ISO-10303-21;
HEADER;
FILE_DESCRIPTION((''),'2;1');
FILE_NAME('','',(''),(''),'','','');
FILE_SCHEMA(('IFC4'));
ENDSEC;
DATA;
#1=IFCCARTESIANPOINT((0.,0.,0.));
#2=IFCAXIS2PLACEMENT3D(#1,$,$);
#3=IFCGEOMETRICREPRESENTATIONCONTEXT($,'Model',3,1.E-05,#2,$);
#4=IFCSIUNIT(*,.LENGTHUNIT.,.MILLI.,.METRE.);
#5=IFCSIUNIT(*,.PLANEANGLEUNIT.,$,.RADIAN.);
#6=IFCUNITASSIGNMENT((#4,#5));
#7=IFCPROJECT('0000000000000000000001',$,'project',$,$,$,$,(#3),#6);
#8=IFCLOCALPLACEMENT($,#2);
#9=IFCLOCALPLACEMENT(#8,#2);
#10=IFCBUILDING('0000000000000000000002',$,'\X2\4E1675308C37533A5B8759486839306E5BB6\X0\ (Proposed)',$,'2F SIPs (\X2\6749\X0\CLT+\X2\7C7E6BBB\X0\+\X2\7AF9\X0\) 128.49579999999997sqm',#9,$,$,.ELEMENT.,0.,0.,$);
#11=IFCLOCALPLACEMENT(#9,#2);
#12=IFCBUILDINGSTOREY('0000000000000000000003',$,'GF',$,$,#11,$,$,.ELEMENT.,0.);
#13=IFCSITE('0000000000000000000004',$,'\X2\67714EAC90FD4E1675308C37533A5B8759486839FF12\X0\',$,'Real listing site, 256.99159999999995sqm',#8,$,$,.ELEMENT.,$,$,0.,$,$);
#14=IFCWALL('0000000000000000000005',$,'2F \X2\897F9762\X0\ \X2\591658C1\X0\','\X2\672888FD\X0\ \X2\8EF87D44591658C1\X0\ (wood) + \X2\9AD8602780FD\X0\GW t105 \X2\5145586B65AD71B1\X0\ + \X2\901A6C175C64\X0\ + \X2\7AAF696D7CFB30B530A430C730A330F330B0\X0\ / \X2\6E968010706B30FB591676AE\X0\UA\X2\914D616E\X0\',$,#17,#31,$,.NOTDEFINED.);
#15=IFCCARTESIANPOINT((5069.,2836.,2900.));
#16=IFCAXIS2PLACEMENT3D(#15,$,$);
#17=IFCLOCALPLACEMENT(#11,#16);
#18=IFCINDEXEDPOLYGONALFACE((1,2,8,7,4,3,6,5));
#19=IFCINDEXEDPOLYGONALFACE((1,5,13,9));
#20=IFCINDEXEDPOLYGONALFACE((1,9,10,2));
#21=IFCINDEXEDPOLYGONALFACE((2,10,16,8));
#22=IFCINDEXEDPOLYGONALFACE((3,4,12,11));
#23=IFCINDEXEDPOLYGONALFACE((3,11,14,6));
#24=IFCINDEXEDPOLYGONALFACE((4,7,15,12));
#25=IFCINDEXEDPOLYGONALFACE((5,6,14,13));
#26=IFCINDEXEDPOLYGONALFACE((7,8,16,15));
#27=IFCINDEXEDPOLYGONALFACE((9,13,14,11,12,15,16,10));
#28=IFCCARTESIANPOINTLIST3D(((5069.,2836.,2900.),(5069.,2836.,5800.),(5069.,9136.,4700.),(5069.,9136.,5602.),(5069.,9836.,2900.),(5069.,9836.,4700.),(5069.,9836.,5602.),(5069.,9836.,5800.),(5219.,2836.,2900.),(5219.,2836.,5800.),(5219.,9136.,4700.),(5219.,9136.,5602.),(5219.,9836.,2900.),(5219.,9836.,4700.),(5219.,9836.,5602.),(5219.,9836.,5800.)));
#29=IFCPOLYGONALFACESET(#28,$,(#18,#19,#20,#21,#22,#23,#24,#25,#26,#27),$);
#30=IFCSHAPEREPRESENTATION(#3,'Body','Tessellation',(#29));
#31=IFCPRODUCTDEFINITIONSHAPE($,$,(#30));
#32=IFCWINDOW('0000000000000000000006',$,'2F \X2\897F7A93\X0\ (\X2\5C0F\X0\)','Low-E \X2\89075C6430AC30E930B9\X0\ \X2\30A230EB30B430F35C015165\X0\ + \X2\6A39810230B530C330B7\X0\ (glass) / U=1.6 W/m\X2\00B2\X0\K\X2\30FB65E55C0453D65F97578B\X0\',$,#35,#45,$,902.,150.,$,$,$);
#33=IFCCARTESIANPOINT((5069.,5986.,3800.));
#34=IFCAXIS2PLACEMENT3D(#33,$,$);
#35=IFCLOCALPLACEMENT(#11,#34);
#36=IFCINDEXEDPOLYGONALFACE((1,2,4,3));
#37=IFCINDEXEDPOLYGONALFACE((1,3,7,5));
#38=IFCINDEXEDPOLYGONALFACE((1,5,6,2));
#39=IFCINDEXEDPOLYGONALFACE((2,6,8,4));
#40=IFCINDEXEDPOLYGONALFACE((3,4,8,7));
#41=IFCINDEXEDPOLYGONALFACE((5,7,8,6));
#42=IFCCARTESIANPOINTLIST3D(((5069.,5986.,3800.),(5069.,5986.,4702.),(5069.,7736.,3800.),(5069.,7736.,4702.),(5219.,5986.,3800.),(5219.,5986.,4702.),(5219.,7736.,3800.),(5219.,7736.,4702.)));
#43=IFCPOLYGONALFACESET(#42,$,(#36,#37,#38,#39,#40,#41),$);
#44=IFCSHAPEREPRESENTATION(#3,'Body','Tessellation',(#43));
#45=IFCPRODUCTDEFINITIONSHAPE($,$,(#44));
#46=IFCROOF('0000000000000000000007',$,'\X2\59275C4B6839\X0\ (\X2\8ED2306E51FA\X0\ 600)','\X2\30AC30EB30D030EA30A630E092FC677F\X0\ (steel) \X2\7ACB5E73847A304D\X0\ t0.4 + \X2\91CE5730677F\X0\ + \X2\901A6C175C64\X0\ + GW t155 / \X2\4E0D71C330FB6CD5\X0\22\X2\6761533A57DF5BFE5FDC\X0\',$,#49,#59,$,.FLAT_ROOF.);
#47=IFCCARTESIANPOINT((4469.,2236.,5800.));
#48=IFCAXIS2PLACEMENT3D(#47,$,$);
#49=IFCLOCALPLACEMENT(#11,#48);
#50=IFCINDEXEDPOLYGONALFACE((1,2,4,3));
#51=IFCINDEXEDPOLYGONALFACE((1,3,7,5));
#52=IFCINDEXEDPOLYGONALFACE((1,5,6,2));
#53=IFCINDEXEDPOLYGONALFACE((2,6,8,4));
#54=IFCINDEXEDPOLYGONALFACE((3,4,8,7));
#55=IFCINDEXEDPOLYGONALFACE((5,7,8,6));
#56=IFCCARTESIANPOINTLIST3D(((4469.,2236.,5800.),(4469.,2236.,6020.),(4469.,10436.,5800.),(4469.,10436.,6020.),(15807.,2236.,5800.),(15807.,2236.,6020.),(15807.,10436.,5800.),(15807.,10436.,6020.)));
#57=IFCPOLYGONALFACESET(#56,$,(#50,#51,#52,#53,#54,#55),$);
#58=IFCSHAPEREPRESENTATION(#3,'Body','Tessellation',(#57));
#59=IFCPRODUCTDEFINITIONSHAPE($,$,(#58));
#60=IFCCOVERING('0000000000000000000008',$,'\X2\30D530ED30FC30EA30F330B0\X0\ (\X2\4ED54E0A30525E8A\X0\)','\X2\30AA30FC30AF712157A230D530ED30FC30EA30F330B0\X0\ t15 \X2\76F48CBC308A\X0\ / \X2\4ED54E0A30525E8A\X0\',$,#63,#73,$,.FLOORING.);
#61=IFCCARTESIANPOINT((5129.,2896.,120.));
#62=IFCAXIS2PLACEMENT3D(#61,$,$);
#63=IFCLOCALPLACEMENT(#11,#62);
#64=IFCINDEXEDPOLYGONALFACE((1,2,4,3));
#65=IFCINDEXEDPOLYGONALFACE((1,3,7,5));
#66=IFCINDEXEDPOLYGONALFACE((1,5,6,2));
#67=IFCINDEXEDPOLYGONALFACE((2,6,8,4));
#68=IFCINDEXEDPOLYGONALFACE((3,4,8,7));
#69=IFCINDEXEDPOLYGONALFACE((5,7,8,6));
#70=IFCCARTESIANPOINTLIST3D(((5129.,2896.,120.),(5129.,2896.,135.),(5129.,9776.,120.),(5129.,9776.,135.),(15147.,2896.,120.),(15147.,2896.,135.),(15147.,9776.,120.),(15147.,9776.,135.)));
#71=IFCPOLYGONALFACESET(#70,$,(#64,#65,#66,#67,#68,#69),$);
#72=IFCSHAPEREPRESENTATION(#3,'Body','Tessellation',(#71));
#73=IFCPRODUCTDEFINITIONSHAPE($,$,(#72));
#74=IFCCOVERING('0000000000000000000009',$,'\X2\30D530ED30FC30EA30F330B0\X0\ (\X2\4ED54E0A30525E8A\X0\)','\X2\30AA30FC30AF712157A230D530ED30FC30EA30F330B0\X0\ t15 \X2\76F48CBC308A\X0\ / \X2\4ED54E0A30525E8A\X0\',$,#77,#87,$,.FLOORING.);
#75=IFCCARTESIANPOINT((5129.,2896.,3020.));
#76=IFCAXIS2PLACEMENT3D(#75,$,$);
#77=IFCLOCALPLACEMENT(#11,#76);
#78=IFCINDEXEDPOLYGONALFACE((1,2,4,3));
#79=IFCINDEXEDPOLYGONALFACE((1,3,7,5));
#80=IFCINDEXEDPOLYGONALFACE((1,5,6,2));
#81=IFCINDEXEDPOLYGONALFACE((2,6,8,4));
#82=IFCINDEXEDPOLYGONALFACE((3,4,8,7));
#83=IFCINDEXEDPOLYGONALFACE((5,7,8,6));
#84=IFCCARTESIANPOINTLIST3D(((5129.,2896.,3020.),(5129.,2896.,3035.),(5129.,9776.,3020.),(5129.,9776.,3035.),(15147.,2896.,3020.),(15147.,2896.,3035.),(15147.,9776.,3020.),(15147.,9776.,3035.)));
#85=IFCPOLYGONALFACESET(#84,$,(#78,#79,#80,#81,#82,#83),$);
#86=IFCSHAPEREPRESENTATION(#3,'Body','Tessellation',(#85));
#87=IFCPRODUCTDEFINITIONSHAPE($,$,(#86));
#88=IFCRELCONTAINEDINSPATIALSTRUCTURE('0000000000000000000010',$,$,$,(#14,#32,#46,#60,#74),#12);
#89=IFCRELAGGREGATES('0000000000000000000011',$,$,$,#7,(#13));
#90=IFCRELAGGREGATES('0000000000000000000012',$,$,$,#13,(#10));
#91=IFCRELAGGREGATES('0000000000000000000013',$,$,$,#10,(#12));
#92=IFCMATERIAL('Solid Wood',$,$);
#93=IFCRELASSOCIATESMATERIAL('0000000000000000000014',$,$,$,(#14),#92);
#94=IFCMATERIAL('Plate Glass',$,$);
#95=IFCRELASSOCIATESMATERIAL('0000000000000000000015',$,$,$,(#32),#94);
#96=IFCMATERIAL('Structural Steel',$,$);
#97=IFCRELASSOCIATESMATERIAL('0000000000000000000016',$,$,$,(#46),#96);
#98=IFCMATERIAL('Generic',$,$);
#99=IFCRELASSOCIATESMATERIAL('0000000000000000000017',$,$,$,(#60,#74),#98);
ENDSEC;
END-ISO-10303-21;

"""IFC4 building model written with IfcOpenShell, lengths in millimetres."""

from ifc_helpers import new_model, si_unit, frame, frame_2d, origin, place, context, project, spatial, rectangle, extrude, material, element, fill, save


model = new_model("IFC4")

# Units and contexts
model_context = context("Model", 3, precision=1e-05, world=origin())
ifc_project = project(units=[si_unit("LENGTHUNIT", "METRE", prefix="MILLI"), si_unit("PLANEANGLEUNIT", "RADIAN")], contexts=[model_context])

# Site, building, storey
site_placement = place(None, origin())
site = spatial("IfcSite", under=ifc_project, at=site_placement, Name="東京都世田谷区宇奈根２", ObjectType="Real listing site, 256.99159999999995sqm", CompositionType="ELEMENT", RefElevation=0.0)
building_placement = place(site_placement, origin())
building = spatial("IfcBuilding", under=site, at=building_placement, Name="世田谷区宇奈根の家 (Proposed)", ObjectType="2F SIPs (杉CLT+籾殻+竹) 128.49579999999997sqm", CompositionType="ELEMENT", ElevationOfRefHeight=0.0, ElevationOfTerrain=0.0)
storey_placement = place(building_placement, origin())
storey = spatial("IfcBuildingStorey", under=building, at=storey_placement, Name="GF", CompositionType="ELEMENT", Elevation=0.0)

# Shared definitions
ifc_material_1 = material(Name="Solid Wood")

# Shared definitions
ifc_material_2 = material(Name="Plate Glass")

# Wall, opening, window
wall_1_placement = place(storey_placement, frame((5069.0, 2836.0, 2900.0)))
wall_1 = element("IfcWall", 1, at=wall_1_placement, inside=storey, material=ifc_material_1, Name="2F 西面 外壁", Description="木製 軸組外壁 (wood) + 高性能GW t105 充填断熱 + 通気層 + 窯業系サイディング / 準耐火・外皮UA配慮", PredefinedType="NOTDEFINED", context=model_context, shape_type="SweptSolid", body=[
    extrude(rectangle(XDim=150.0, YDim=7000.0, at=frame_2d((75.0, 3500.0))), frame((5069.0, 2836.0, 2900.0)), (0.0, 0.0, 1.0), 2900.0),
])
opening_1_placement = place(storey_placement, frame((5069.0, 5986.0, 3800.0)))
opening_1 = element("IfcOpeningElement", 2, at=opening_1_placement, cuts=wall_1, PredefinedType="NOTDEFINED", context=model_context, shape_type="SweptSolid", body=[
    extrude(rectangle(XDim=150.0, YDim=1750.0, at=frame_2d((75.0, 875.0))), frame((5069.0, 5986.0, 3800.0)), (0.0, 0.0, 1.0), 902.0),
])
window_1_placement = place(storey_placement, frame((5069.0, 5986.0, 3800.0)))
window_1 = element("IfcWindow", 3, at=window_1_placement, inside=storey, material=ifc_material_2, Name="2F 西窓 (小)", Description="Low-E 複層ガラス アルゴン封入 + 樹脂サッシ (glass) / U=1.6 W/m²K・日射取得型", OverallHeight=902.0, OverallWidth=150.0, context=model_context, shape_type="SweptSolid", body=[
    extrude(rectangle(XDim=150.0, YDim=1750.0, at=frame_2d((75.0, 875.0))), frame((5069.0, 5986.0, 3800.0)), (0.0, 0.0, 1.0), 902.0),
])
fill(opening_1, window_1)

# Roof
ifc_material_3 = material(Name="Structural Steel")
roof_placement = place(storey_placement, frame((4469.0, 2236.0, 5800.0)))
element("IfcRoof", 4, at=roof_placement, inside=storey, material=ifc_material_3, Name="大屋根 (軒の出 600)", Description="ガルバリウム鋼板 (steel) 立平葺き t0.4 + 野地板 + 通気層 + GW t155 / 不燃・法22条区域対応", PredefinedType="FLAT_ROOF", context=model_context, shape_type="SweptSolid", body=[
    extrude(rectangle(XDim=11338.0, YDim=8200.0, at=frame_2d((5669.0, 4100.0))), frame((4469.0, 2236.0, 5800.0)), (0.0, 0.0, 1.0), 220.0),
])

# Coverings
ifc_material_4 = material(Name="Generic")
covering_1_placement = place(storey_placement, frame((5129.0, 2896.0, 120.0)))
element("IfcCovering", 5, at=covering_1_placement, inside=storey, material=ifc_material_4, Name="フローリング (仕上げ床)", Description="オーク無垢フローリング t15 直貼り / 仕上げ床", PredefinedType="FLOORING", context=model_context, shape_type="SweptSolid", body=[
    extrude(rectangle(XDim=10018.0, YDim=6880.0, at=frame_2d((5009.0, 3440.0))), frame((5129.0, 2896.0, 120.0)), (0.0, 0.0, 1.0), 15.0),
])
covering_2_placement = place(storey_placement, frame((5129.0, 2896.0, 3020.0)))
element("IfcCovering", 6, at=covering_2_placement, inside=storey, material=ifc_material_4, Name="フローリング (仕上げ床)", Description="オーク無垢フローリング t15 直貼り / 仕上げ床", PredefinedType="FLOORING", context=model_context, shape_type="SweptSolid", body=[
    extrude(rectangle(XDim=10018.0, YDim=6880.0, at=frame_2d((5009.0, 3440.0))), frame((5129.0, 2896.0, 3020.0)), (0.0, 0.0, 1.0), 15.0),
])

save(model, "model.ifc")
